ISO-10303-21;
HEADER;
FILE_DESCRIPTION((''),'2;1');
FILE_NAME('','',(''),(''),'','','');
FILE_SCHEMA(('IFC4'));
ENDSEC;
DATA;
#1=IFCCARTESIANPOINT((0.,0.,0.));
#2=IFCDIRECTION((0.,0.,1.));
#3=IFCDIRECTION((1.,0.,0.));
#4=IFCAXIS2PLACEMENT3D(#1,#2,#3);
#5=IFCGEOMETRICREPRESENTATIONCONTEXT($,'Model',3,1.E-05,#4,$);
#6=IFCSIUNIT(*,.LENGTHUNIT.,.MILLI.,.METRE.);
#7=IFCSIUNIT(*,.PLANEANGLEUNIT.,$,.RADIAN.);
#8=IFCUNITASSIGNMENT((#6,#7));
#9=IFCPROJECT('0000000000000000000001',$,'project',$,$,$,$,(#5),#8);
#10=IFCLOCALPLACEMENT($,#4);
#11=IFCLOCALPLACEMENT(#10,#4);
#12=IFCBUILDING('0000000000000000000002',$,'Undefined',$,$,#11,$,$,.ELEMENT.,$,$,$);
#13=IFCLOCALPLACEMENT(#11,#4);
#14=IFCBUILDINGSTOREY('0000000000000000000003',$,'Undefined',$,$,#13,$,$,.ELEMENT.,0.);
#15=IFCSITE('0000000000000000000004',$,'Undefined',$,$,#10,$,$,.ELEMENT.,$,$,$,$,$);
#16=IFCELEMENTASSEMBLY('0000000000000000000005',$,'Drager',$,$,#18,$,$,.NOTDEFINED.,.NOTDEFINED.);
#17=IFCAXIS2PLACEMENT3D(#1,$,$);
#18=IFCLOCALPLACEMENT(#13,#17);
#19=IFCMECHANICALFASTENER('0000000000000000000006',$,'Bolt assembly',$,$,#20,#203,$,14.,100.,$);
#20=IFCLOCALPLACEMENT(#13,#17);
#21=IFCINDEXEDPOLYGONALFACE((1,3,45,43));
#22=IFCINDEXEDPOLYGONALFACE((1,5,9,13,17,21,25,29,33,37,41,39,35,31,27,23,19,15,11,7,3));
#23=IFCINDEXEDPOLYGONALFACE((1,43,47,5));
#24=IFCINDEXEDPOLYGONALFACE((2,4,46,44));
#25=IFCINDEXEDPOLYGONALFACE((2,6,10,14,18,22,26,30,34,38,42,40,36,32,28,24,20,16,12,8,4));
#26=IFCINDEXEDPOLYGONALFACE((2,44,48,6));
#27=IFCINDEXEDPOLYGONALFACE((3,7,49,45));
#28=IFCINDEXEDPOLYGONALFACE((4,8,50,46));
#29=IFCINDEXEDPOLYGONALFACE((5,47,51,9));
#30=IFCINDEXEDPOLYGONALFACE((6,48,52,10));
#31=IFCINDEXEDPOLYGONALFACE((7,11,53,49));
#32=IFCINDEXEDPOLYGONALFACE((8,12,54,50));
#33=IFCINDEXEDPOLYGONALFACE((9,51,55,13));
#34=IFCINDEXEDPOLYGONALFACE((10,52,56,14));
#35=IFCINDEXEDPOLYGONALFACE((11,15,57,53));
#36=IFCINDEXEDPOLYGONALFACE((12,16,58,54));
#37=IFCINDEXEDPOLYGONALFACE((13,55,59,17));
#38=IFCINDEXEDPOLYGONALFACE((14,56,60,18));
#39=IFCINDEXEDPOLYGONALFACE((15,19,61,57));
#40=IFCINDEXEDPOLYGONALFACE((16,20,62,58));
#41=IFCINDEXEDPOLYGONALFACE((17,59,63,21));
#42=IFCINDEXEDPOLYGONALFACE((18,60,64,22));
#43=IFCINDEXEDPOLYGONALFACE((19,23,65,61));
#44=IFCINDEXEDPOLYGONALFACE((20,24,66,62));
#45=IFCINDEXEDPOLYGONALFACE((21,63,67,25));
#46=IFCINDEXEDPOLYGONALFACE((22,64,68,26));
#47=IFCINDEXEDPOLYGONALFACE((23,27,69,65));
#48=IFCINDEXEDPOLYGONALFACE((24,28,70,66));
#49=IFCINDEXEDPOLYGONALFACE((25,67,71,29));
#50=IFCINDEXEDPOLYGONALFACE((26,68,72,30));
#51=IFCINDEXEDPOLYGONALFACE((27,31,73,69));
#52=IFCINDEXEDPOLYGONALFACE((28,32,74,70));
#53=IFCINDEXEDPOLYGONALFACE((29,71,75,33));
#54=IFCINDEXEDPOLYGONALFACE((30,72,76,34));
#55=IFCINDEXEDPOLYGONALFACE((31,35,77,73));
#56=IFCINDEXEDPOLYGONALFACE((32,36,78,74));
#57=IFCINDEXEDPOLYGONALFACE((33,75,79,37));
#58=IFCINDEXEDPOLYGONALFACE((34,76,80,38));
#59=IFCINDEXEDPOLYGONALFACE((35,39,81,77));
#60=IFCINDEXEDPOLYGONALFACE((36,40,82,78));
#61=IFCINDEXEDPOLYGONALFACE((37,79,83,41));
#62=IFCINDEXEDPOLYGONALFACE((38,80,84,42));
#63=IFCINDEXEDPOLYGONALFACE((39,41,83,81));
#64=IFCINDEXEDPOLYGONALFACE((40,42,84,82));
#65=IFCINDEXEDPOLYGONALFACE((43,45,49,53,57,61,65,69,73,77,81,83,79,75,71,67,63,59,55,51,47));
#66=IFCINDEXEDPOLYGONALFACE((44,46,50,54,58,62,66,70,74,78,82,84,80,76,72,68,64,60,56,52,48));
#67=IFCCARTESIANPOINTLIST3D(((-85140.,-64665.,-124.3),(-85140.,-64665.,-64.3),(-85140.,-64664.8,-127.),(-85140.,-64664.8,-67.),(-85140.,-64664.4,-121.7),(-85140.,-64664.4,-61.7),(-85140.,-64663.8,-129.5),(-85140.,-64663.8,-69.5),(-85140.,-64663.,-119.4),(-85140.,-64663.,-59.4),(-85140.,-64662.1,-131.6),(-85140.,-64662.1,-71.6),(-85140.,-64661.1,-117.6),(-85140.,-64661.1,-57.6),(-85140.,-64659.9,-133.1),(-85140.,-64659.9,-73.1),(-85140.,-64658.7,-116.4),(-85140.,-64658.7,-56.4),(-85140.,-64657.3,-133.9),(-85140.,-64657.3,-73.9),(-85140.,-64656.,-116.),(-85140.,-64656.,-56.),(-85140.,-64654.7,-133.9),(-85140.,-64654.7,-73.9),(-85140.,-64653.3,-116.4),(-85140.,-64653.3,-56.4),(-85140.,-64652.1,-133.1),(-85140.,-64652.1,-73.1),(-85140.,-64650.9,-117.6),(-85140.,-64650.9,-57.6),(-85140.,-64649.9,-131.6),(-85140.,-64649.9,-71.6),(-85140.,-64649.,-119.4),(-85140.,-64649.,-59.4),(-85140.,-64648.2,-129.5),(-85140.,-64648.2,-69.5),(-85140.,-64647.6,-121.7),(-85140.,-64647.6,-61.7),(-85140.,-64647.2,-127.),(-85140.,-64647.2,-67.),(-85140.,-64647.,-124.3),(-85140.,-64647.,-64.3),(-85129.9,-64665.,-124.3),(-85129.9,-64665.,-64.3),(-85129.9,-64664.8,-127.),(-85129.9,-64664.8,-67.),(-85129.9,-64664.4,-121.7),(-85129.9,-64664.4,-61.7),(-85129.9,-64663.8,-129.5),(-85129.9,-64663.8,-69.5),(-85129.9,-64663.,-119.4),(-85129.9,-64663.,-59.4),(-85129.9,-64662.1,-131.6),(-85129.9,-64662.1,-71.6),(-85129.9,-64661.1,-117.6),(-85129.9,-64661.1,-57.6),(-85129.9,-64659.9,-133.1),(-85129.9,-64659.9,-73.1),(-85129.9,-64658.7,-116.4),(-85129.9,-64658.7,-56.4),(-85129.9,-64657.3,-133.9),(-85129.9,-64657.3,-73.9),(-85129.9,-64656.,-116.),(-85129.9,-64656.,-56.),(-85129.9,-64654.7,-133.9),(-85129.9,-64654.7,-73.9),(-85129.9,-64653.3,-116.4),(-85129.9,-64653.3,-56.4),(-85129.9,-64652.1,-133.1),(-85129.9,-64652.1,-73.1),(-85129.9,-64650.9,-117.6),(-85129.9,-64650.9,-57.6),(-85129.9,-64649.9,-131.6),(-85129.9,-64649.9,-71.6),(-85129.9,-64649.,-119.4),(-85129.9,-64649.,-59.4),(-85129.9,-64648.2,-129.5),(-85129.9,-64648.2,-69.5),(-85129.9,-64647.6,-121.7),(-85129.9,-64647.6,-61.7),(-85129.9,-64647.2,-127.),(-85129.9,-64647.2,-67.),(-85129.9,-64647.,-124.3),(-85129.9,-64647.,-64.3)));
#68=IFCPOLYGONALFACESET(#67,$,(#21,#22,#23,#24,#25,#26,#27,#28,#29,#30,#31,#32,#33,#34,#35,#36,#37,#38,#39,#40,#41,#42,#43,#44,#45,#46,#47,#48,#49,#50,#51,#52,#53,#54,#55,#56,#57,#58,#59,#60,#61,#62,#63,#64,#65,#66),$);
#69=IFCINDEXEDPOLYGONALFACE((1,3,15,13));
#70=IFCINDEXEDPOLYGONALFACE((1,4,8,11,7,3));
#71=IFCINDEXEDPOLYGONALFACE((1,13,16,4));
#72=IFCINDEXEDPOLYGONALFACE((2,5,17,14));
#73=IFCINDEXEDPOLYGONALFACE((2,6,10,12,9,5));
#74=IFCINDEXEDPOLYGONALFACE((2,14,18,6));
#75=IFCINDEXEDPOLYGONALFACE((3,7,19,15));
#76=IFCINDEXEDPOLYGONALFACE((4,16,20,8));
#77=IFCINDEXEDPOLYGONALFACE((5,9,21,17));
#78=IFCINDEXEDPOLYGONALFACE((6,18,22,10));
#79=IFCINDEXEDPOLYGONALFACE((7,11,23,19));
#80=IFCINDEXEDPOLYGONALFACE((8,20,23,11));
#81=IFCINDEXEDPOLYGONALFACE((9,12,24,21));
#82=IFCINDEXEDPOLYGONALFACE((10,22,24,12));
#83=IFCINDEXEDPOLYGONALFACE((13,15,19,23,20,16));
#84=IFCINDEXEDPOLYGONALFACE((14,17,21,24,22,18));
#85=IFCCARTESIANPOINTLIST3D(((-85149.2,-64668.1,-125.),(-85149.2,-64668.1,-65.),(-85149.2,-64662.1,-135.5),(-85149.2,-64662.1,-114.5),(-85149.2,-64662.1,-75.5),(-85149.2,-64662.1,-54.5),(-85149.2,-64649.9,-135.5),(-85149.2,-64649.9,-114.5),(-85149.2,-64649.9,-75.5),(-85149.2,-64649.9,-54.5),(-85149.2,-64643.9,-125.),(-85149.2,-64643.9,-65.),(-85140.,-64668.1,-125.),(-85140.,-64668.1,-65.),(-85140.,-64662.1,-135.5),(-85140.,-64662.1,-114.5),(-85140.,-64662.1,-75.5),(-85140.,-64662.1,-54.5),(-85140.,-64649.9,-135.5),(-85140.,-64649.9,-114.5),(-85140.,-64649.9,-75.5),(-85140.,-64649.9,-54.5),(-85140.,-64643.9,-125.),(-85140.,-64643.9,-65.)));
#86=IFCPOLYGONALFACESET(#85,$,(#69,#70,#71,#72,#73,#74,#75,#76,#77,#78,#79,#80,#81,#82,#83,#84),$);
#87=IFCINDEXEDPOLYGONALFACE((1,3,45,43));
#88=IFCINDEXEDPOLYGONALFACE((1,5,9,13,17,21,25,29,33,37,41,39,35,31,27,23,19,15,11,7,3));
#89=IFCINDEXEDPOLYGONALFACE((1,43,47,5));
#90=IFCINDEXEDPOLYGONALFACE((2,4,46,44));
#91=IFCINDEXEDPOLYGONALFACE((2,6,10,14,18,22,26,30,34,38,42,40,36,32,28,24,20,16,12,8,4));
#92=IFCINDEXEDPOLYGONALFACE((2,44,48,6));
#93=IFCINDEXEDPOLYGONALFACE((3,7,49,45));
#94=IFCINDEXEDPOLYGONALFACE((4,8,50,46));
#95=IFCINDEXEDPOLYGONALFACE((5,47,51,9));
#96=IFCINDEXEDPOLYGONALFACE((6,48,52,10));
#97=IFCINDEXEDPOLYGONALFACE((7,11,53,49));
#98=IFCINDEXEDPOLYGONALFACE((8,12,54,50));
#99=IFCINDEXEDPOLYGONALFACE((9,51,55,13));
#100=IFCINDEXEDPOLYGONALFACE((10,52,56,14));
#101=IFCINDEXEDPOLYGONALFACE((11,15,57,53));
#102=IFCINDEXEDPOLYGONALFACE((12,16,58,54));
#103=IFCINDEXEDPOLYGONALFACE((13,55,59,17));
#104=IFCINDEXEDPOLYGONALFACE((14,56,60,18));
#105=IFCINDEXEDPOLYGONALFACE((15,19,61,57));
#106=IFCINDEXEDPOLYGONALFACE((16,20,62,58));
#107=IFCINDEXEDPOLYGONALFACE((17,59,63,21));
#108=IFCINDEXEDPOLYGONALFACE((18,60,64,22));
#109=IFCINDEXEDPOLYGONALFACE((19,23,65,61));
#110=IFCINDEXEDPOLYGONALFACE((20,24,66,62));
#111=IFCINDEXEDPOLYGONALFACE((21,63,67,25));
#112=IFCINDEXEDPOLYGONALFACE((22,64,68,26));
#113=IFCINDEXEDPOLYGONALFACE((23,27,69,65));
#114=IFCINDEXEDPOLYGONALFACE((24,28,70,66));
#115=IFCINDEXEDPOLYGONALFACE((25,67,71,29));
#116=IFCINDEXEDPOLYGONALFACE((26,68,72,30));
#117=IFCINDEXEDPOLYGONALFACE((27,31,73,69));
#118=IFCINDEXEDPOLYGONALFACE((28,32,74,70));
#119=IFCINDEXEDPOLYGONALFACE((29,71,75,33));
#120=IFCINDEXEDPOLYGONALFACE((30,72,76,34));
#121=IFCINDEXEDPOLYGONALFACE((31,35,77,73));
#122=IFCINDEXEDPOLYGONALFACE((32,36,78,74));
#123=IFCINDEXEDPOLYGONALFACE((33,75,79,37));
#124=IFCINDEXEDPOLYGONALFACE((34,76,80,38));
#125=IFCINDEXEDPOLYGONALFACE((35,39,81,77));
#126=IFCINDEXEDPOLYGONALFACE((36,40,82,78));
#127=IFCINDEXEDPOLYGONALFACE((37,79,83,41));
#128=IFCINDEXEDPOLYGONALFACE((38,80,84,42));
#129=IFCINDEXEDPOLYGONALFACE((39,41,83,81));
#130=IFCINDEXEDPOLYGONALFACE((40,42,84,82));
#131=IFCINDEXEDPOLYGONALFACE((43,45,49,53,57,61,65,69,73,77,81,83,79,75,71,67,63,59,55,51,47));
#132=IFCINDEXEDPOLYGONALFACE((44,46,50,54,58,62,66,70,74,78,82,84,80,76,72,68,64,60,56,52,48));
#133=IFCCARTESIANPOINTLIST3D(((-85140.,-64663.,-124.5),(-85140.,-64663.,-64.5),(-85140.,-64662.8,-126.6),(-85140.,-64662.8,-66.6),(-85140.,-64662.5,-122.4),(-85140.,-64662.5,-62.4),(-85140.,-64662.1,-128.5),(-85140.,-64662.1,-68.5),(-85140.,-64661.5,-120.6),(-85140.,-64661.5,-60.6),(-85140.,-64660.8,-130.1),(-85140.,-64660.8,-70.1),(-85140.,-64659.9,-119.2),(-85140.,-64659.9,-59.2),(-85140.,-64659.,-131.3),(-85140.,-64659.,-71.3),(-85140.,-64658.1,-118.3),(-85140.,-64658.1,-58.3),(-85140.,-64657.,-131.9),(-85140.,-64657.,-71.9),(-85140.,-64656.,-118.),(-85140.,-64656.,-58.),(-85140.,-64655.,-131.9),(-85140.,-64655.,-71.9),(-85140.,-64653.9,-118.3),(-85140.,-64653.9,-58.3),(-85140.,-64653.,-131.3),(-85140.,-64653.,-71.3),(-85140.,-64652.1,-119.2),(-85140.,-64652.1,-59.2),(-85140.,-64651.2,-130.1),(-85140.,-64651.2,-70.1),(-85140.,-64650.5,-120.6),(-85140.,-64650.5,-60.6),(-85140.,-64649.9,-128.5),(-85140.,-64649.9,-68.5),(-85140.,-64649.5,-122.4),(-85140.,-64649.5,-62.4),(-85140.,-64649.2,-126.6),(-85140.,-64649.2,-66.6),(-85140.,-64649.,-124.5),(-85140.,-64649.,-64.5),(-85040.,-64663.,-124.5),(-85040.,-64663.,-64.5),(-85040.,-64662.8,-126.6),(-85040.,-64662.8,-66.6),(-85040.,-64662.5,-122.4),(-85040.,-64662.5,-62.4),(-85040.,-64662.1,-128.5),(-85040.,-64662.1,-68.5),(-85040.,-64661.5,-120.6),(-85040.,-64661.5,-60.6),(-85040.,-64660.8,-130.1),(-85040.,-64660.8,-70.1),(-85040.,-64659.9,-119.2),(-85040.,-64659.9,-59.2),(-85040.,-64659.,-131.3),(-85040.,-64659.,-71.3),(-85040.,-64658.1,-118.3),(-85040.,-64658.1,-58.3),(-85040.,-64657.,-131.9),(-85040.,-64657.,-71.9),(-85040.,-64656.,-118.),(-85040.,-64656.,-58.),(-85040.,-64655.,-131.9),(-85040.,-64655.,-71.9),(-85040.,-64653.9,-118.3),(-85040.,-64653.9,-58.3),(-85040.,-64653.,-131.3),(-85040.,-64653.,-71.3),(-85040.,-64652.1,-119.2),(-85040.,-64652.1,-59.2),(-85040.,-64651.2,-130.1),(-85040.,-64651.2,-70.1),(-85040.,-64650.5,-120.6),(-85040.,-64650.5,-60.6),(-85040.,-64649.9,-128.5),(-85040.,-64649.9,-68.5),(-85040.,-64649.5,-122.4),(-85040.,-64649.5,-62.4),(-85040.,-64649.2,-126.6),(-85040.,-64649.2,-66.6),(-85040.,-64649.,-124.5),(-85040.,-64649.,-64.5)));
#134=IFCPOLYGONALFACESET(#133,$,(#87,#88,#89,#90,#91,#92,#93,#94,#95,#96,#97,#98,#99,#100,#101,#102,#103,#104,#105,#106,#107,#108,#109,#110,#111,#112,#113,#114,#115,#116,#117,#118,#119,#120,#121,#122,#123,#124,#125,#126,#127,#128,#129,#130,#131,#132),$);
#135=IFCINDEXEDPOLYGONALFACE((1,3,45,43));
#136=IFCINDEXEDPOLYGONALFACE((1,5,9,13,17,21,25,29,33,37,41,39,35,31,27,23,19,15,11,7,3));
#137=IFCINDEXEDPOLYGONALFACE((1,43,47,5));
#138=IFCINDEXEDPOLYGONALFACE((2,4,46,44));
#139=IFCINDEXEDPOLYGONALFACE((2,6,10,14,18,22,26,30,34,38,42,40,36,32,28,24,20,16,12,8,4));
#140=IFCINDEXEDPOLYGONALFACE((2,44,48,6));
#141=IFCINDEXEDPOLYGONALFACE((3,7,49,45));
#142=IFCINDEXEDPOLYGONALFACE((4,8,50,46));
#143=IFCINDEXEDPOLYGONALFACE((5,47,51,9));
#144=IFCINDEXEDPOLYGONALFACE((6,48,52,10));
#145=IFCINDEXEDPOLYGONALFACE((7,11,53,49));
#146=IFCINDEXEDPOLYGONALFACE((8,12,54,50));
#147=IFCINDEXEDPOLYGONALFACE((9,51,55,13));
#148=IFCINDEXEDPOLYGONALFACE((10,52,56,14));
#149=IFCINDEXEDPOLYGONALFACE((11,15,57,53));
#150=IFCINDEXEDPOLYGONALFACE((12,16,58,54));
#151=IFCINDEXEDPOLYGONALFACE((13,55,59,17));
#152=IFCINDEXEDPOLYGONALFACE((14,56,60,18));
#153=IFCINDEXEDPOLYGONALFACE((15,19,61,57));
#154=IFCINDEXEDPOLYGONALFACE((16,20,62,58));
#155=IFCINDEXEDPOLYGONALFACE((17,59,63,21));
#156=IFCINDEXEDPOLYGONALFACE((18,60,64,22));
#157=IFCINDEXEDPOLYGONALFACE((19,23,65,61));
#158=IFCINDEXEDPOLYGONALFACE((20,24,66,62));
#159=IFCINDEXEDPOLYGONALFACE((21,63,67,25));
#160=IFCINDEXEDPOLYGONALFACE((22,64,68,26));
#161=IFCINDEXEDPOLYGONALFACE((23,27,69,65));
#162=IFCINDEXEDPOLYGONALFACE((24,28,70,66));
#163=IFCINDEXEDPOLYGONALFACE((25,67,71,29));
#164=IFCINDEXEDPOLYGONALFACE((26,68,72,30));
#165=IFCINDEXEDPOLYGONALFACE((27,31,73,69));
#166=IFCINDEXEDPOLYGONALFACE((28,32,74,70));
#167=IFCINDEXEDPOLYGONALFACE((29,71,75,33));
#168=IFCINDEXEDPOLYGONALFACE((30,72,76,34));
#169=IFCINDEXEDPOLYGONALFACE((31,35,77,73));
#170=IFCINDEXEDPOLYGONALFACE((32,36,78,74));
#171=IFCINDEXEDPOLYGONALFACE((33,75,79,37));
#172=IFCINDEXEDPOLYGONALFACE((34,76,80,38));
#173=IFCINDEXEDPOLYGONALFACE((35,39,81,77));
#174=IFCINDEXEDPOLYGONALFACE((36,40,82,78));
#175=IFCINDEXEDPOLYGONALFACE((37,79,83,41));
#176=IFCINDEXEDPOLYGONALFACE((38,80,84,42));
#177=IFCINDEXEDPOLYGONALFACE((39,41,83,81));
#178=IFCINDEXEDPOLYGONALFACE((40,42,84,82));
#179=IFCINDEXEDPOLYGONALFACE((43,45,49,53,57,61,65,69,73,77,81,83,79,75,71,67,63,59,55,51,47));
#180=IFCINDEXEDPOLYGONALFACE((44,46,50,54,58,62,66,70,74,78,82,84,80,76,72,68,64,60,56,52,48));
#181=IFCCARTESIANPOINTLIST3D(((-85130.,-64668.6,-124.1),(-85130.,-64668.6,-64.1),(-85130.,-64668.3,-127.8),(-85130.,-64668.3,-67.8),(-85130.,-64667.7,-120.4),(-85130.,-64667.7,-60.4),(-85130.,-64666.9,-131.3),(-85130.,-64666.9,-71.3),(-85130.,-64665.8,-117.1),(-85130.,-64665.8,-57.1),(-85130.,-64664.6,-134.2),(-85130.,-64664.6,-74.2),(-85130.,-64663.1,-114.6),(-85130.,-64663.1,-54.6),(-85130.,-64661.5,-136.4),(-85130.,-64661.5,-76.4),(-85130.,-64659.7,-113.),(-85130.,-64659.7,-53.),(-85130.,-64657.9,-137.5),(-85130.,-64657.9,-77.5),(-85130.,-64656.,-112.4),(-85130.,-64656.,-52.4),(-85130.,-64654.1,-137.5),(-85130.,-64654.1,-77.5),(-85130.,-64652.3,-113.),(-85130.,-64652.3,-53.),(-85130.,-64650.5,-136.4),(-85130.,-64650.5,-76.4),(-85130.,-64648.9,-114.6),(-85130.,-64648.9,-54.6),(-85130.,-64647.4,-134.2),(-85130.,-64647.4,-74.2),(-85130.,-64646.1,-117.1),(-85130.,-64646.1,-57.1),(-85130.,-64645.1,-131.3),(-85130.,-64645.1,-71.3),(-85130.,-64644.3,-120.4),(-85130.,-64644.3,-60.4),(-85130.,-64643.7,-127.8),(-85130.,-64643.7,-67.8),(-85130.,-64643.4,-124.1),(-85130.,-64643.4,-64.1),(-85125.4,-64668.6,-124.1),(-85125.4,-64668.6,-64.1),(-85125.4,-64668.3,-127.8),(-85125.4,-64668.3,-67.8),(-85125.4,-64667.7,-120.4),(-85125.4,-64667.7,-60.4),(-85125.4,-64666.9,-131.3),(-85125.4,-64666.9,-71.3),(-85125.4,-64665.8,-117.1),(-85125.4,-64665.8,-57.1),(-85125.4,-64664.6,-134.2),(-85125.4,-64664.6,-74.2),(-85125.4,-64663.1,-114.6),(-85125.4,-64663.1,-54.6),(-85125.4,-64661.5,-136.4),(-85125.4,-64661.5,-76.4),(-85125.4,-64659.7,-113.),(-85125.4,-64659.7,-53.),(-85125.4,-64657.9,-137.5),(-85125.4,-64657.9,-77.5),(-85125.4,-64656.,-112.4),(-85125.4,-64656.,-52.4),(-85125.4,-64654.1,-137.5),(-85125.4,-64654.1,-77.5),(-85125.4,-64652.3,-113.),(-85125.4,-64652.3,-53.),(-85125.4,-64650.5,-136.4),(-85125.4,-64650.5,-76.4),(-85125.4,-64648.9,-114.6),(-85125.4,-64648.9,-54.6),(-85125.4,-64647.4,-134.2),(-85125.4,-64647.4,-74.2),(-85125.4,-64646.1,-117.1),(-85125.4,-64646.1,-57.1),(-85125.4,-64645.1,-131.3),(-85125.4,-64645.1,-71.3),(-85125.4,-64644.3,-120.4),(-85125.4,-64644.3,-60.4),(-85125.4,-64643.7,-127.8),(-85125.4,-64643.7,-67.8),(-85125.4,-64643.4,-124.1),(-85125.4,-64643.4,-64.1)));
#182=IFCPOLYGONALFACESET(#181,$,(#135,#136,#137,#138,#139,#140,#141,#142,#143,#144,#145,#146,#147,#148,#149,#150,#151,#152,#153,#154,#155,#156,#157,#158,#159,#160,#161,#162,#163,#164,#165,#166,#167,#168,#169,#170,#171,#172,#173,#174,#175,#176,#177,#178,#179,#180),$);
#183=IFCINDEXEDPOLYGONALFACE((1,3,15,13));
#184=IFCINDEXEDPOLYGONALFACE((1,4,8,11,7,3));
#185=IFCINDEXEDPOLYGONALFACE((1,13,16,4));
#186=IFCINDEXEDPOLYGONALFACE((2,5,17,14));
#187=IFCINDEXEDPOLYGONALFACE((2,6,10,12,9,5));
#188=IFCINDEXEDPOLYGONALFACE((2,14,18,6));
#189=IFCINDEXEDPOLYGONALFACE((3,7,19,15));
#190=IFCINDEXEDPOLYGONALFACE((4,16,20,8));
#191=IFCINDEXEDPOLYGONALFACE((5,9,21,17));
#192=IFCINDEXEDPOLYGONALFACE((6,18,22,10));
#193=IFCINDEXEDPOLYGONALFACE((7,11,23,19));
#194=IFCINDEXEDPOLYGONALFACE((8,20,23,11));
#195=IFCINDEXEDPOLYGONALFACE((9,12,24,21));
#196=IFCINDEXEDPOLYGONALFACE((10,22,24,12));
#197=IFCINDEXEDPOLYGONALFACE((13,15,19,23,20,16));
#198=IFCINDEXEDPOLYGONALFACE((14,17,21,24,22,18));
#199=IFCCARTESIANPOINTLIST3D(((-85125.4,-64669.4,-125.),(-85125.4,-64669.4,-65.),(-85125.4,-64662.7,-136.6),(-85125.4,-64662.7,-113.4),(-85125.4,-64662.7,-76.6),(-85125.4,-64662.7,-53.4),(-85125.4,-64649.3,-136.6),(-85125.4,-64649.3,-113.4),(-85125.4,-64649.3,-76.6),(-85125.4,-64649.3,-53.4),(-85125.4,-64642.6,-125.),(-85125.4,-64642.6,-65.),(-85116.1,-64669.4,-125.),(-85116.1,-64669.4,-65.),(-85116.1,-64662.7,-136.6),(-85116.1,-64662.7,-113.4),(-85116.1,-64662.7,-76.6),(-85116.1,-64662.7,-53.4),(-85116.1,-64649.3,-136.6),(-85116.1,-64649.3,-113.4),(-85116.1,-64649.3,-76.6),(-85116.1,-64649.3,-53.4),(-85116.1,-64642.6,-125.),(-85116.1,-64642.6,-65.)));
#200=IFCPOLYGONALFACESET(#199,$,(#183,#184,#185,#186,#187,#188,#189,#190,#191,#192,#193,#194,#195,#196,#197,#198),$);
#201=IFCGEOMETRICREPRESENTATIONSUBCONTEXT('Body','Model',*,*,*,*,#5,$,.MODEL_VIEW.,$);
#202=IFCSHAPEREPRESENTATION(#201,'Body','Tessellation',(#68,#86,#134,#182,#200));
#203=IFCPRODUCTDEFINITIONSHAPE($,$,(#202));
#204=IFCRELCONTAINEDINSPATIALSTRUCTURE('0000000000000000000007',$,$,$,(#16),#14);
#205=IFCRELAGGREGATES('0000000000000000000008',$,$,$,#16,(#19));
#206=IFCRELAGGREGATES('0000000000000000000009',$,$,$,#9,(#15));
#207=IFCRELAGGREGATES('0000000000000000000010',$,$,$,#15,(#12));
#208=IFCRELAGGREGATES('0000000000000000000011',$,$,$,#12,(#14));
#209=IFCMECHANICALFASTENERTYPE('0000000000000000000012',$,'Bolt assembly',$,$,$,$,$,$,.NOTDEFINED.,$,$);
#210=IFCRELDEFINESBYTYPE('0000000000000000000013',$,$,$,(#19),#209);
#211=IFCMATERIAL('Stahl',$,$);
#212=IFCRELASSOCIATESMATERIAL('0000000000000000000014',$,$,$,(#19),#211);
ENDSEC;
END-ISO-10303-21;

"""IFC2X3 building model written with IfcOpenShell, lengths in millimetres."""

from ifc_helpers import new_model, si_unit, frame, origin_with_axes, origin_2d_with_axis, place, context, subcontext, project, spatial, polyline, circle, outline, extrude, source, transform, mapped, material, type_object, element, aggregate, save


model = new_model("IFC2X3")

# Units and contexts
model_context = context("Model", 3, precision=1e-05, world=origin_with_axes())
body_context = subcontext(model_context, "Body", "Model", "MODEL_VIEW")
ifc_project = project(units=[si_unit("LENGTHUNIT", "METRE", prefix="MILLI"), si_unit("PLANEANGLEUNIT", "RADIAN")], contexts=[model_context])

# Site, building, storey
site_placement = place(None, origin_with_axes())
site = spatial("IfcSite", under=ifc_project, at=site_placement, Name="Undefined", CompositionType="ELEMENT")
building_placement = place(site_placement, origin_with_axes())
building = spatial("IfcBuilding", under=site, at=building_placement, Name="Undefined", CompositionType="ELEMENT")
storey_placement = place(building_placement, origin_with_axes())
storey = spatial("IfcBuildingStorey", under=building, at=storey_placement, Name="Undefined", CompositionType="ELEMENT", Elevation=0.0)

# Element assembly
assembly_1_placement = place(storey_placement, origin_with_axes())
assembly_1 = element("IfcElementAssembly", 1, at=assembly_1_placement, inside=storey, Name="Drager", AssemblyPlace="NOTDEFINED", PredefinedType="NOTDEFINED")

# Shared definitions
mechanical_fastener_type = type_object("IfcMechanicalFastenerType", Name="Bolt assembly")

# Mechanical fastener
ifc_material_1 = material(Name="Stahl")
shared_shape_1 = source(origin_with_axes(), body_context, "Body", "SweptSolid", [
    extrude(circle(Radius=9.0, at=origin_2d_with_axis()), frame((0.0, 0.0, 0.0), z_axis=(0.0, 1.0, 0.0), x_axis=(1.0, 0.0, 0.0)), (0.0, 0.0, 1.0), 10.1),
    extrude(outline(polyline([(10.5, -6.1), (10.5, 6.1), (0.0, 12.1), (-10.5, 6.1), (-10.5, -6.1), (0.0, -12.1), (10.5, -6.1)])), frame((0.0, -9.2, 0.0), z_axis=(0.0, 1.0, 0.0), x_axis=(1.0, 0.0, 0.0)), (0.0, 0.0, 1.0), 9.2),
    extrude(circle(Radius=7.0, at=origin_2d_with_axis()), frame((0.0, 0.0, 0.0), z_axis=(0.0, 1.0, 0.0), x_axis=(1.0, 0.0, 0.0)), (0.0, 0.0, 1.0), 100.0),
    extrude(circle(Radius=12.6, at=origin_2d_with_axis()), frame((0.0, 10.0, 0.0), z_axis=(0.0, 1.0, 0.0), x_axis=(1.0, 0.0, 0.0)), (0.0, 0.0, 1.0), 4.6),
    extrude(outline(polyline([(11.6, -6.7), (11.6, 6.7), (0.0, 13.4), (-11.6, 6.7), (-11.6, -6.7), (0.0, -13.4), (11.6, -6.7)])), frame((0.0, 14.6, 0.0), z_axis=(0.0, 1.0, 0.0), x_axis=(1.0, 0.0, 0.0)), (0.0, 0.0, 1.0), 9.2),
])
mechanical_fastener_1_placement = place(assembly_1_placement, frame((-85140.0, -64656.0, -125.0), z_axis=(0.0, 1.0, 0.0), x_axis=(0.0, 0.0, 1.0)))
mechanical_fastener_1 = element("IfcMechanicalFastener", 2, at=mechanical_fastener_1_placement, type_object=mechanical_fastener_type, material=ifc_material_1, Name="Bolt assembly", NominalDiameter=14.0, NominalLength=100.0, context=body_context, shape_type="MappedRepresentation", body=[
    mapped(shared_shape_1, transform((0.0, 0.0, 0.0))),
    mapped(shared_shape_1, transform((60.0, 0.0, 0.0))),
])
aggregate(assembly_1, [mechanical_fastener_1])

save(model, "model.ifc")
